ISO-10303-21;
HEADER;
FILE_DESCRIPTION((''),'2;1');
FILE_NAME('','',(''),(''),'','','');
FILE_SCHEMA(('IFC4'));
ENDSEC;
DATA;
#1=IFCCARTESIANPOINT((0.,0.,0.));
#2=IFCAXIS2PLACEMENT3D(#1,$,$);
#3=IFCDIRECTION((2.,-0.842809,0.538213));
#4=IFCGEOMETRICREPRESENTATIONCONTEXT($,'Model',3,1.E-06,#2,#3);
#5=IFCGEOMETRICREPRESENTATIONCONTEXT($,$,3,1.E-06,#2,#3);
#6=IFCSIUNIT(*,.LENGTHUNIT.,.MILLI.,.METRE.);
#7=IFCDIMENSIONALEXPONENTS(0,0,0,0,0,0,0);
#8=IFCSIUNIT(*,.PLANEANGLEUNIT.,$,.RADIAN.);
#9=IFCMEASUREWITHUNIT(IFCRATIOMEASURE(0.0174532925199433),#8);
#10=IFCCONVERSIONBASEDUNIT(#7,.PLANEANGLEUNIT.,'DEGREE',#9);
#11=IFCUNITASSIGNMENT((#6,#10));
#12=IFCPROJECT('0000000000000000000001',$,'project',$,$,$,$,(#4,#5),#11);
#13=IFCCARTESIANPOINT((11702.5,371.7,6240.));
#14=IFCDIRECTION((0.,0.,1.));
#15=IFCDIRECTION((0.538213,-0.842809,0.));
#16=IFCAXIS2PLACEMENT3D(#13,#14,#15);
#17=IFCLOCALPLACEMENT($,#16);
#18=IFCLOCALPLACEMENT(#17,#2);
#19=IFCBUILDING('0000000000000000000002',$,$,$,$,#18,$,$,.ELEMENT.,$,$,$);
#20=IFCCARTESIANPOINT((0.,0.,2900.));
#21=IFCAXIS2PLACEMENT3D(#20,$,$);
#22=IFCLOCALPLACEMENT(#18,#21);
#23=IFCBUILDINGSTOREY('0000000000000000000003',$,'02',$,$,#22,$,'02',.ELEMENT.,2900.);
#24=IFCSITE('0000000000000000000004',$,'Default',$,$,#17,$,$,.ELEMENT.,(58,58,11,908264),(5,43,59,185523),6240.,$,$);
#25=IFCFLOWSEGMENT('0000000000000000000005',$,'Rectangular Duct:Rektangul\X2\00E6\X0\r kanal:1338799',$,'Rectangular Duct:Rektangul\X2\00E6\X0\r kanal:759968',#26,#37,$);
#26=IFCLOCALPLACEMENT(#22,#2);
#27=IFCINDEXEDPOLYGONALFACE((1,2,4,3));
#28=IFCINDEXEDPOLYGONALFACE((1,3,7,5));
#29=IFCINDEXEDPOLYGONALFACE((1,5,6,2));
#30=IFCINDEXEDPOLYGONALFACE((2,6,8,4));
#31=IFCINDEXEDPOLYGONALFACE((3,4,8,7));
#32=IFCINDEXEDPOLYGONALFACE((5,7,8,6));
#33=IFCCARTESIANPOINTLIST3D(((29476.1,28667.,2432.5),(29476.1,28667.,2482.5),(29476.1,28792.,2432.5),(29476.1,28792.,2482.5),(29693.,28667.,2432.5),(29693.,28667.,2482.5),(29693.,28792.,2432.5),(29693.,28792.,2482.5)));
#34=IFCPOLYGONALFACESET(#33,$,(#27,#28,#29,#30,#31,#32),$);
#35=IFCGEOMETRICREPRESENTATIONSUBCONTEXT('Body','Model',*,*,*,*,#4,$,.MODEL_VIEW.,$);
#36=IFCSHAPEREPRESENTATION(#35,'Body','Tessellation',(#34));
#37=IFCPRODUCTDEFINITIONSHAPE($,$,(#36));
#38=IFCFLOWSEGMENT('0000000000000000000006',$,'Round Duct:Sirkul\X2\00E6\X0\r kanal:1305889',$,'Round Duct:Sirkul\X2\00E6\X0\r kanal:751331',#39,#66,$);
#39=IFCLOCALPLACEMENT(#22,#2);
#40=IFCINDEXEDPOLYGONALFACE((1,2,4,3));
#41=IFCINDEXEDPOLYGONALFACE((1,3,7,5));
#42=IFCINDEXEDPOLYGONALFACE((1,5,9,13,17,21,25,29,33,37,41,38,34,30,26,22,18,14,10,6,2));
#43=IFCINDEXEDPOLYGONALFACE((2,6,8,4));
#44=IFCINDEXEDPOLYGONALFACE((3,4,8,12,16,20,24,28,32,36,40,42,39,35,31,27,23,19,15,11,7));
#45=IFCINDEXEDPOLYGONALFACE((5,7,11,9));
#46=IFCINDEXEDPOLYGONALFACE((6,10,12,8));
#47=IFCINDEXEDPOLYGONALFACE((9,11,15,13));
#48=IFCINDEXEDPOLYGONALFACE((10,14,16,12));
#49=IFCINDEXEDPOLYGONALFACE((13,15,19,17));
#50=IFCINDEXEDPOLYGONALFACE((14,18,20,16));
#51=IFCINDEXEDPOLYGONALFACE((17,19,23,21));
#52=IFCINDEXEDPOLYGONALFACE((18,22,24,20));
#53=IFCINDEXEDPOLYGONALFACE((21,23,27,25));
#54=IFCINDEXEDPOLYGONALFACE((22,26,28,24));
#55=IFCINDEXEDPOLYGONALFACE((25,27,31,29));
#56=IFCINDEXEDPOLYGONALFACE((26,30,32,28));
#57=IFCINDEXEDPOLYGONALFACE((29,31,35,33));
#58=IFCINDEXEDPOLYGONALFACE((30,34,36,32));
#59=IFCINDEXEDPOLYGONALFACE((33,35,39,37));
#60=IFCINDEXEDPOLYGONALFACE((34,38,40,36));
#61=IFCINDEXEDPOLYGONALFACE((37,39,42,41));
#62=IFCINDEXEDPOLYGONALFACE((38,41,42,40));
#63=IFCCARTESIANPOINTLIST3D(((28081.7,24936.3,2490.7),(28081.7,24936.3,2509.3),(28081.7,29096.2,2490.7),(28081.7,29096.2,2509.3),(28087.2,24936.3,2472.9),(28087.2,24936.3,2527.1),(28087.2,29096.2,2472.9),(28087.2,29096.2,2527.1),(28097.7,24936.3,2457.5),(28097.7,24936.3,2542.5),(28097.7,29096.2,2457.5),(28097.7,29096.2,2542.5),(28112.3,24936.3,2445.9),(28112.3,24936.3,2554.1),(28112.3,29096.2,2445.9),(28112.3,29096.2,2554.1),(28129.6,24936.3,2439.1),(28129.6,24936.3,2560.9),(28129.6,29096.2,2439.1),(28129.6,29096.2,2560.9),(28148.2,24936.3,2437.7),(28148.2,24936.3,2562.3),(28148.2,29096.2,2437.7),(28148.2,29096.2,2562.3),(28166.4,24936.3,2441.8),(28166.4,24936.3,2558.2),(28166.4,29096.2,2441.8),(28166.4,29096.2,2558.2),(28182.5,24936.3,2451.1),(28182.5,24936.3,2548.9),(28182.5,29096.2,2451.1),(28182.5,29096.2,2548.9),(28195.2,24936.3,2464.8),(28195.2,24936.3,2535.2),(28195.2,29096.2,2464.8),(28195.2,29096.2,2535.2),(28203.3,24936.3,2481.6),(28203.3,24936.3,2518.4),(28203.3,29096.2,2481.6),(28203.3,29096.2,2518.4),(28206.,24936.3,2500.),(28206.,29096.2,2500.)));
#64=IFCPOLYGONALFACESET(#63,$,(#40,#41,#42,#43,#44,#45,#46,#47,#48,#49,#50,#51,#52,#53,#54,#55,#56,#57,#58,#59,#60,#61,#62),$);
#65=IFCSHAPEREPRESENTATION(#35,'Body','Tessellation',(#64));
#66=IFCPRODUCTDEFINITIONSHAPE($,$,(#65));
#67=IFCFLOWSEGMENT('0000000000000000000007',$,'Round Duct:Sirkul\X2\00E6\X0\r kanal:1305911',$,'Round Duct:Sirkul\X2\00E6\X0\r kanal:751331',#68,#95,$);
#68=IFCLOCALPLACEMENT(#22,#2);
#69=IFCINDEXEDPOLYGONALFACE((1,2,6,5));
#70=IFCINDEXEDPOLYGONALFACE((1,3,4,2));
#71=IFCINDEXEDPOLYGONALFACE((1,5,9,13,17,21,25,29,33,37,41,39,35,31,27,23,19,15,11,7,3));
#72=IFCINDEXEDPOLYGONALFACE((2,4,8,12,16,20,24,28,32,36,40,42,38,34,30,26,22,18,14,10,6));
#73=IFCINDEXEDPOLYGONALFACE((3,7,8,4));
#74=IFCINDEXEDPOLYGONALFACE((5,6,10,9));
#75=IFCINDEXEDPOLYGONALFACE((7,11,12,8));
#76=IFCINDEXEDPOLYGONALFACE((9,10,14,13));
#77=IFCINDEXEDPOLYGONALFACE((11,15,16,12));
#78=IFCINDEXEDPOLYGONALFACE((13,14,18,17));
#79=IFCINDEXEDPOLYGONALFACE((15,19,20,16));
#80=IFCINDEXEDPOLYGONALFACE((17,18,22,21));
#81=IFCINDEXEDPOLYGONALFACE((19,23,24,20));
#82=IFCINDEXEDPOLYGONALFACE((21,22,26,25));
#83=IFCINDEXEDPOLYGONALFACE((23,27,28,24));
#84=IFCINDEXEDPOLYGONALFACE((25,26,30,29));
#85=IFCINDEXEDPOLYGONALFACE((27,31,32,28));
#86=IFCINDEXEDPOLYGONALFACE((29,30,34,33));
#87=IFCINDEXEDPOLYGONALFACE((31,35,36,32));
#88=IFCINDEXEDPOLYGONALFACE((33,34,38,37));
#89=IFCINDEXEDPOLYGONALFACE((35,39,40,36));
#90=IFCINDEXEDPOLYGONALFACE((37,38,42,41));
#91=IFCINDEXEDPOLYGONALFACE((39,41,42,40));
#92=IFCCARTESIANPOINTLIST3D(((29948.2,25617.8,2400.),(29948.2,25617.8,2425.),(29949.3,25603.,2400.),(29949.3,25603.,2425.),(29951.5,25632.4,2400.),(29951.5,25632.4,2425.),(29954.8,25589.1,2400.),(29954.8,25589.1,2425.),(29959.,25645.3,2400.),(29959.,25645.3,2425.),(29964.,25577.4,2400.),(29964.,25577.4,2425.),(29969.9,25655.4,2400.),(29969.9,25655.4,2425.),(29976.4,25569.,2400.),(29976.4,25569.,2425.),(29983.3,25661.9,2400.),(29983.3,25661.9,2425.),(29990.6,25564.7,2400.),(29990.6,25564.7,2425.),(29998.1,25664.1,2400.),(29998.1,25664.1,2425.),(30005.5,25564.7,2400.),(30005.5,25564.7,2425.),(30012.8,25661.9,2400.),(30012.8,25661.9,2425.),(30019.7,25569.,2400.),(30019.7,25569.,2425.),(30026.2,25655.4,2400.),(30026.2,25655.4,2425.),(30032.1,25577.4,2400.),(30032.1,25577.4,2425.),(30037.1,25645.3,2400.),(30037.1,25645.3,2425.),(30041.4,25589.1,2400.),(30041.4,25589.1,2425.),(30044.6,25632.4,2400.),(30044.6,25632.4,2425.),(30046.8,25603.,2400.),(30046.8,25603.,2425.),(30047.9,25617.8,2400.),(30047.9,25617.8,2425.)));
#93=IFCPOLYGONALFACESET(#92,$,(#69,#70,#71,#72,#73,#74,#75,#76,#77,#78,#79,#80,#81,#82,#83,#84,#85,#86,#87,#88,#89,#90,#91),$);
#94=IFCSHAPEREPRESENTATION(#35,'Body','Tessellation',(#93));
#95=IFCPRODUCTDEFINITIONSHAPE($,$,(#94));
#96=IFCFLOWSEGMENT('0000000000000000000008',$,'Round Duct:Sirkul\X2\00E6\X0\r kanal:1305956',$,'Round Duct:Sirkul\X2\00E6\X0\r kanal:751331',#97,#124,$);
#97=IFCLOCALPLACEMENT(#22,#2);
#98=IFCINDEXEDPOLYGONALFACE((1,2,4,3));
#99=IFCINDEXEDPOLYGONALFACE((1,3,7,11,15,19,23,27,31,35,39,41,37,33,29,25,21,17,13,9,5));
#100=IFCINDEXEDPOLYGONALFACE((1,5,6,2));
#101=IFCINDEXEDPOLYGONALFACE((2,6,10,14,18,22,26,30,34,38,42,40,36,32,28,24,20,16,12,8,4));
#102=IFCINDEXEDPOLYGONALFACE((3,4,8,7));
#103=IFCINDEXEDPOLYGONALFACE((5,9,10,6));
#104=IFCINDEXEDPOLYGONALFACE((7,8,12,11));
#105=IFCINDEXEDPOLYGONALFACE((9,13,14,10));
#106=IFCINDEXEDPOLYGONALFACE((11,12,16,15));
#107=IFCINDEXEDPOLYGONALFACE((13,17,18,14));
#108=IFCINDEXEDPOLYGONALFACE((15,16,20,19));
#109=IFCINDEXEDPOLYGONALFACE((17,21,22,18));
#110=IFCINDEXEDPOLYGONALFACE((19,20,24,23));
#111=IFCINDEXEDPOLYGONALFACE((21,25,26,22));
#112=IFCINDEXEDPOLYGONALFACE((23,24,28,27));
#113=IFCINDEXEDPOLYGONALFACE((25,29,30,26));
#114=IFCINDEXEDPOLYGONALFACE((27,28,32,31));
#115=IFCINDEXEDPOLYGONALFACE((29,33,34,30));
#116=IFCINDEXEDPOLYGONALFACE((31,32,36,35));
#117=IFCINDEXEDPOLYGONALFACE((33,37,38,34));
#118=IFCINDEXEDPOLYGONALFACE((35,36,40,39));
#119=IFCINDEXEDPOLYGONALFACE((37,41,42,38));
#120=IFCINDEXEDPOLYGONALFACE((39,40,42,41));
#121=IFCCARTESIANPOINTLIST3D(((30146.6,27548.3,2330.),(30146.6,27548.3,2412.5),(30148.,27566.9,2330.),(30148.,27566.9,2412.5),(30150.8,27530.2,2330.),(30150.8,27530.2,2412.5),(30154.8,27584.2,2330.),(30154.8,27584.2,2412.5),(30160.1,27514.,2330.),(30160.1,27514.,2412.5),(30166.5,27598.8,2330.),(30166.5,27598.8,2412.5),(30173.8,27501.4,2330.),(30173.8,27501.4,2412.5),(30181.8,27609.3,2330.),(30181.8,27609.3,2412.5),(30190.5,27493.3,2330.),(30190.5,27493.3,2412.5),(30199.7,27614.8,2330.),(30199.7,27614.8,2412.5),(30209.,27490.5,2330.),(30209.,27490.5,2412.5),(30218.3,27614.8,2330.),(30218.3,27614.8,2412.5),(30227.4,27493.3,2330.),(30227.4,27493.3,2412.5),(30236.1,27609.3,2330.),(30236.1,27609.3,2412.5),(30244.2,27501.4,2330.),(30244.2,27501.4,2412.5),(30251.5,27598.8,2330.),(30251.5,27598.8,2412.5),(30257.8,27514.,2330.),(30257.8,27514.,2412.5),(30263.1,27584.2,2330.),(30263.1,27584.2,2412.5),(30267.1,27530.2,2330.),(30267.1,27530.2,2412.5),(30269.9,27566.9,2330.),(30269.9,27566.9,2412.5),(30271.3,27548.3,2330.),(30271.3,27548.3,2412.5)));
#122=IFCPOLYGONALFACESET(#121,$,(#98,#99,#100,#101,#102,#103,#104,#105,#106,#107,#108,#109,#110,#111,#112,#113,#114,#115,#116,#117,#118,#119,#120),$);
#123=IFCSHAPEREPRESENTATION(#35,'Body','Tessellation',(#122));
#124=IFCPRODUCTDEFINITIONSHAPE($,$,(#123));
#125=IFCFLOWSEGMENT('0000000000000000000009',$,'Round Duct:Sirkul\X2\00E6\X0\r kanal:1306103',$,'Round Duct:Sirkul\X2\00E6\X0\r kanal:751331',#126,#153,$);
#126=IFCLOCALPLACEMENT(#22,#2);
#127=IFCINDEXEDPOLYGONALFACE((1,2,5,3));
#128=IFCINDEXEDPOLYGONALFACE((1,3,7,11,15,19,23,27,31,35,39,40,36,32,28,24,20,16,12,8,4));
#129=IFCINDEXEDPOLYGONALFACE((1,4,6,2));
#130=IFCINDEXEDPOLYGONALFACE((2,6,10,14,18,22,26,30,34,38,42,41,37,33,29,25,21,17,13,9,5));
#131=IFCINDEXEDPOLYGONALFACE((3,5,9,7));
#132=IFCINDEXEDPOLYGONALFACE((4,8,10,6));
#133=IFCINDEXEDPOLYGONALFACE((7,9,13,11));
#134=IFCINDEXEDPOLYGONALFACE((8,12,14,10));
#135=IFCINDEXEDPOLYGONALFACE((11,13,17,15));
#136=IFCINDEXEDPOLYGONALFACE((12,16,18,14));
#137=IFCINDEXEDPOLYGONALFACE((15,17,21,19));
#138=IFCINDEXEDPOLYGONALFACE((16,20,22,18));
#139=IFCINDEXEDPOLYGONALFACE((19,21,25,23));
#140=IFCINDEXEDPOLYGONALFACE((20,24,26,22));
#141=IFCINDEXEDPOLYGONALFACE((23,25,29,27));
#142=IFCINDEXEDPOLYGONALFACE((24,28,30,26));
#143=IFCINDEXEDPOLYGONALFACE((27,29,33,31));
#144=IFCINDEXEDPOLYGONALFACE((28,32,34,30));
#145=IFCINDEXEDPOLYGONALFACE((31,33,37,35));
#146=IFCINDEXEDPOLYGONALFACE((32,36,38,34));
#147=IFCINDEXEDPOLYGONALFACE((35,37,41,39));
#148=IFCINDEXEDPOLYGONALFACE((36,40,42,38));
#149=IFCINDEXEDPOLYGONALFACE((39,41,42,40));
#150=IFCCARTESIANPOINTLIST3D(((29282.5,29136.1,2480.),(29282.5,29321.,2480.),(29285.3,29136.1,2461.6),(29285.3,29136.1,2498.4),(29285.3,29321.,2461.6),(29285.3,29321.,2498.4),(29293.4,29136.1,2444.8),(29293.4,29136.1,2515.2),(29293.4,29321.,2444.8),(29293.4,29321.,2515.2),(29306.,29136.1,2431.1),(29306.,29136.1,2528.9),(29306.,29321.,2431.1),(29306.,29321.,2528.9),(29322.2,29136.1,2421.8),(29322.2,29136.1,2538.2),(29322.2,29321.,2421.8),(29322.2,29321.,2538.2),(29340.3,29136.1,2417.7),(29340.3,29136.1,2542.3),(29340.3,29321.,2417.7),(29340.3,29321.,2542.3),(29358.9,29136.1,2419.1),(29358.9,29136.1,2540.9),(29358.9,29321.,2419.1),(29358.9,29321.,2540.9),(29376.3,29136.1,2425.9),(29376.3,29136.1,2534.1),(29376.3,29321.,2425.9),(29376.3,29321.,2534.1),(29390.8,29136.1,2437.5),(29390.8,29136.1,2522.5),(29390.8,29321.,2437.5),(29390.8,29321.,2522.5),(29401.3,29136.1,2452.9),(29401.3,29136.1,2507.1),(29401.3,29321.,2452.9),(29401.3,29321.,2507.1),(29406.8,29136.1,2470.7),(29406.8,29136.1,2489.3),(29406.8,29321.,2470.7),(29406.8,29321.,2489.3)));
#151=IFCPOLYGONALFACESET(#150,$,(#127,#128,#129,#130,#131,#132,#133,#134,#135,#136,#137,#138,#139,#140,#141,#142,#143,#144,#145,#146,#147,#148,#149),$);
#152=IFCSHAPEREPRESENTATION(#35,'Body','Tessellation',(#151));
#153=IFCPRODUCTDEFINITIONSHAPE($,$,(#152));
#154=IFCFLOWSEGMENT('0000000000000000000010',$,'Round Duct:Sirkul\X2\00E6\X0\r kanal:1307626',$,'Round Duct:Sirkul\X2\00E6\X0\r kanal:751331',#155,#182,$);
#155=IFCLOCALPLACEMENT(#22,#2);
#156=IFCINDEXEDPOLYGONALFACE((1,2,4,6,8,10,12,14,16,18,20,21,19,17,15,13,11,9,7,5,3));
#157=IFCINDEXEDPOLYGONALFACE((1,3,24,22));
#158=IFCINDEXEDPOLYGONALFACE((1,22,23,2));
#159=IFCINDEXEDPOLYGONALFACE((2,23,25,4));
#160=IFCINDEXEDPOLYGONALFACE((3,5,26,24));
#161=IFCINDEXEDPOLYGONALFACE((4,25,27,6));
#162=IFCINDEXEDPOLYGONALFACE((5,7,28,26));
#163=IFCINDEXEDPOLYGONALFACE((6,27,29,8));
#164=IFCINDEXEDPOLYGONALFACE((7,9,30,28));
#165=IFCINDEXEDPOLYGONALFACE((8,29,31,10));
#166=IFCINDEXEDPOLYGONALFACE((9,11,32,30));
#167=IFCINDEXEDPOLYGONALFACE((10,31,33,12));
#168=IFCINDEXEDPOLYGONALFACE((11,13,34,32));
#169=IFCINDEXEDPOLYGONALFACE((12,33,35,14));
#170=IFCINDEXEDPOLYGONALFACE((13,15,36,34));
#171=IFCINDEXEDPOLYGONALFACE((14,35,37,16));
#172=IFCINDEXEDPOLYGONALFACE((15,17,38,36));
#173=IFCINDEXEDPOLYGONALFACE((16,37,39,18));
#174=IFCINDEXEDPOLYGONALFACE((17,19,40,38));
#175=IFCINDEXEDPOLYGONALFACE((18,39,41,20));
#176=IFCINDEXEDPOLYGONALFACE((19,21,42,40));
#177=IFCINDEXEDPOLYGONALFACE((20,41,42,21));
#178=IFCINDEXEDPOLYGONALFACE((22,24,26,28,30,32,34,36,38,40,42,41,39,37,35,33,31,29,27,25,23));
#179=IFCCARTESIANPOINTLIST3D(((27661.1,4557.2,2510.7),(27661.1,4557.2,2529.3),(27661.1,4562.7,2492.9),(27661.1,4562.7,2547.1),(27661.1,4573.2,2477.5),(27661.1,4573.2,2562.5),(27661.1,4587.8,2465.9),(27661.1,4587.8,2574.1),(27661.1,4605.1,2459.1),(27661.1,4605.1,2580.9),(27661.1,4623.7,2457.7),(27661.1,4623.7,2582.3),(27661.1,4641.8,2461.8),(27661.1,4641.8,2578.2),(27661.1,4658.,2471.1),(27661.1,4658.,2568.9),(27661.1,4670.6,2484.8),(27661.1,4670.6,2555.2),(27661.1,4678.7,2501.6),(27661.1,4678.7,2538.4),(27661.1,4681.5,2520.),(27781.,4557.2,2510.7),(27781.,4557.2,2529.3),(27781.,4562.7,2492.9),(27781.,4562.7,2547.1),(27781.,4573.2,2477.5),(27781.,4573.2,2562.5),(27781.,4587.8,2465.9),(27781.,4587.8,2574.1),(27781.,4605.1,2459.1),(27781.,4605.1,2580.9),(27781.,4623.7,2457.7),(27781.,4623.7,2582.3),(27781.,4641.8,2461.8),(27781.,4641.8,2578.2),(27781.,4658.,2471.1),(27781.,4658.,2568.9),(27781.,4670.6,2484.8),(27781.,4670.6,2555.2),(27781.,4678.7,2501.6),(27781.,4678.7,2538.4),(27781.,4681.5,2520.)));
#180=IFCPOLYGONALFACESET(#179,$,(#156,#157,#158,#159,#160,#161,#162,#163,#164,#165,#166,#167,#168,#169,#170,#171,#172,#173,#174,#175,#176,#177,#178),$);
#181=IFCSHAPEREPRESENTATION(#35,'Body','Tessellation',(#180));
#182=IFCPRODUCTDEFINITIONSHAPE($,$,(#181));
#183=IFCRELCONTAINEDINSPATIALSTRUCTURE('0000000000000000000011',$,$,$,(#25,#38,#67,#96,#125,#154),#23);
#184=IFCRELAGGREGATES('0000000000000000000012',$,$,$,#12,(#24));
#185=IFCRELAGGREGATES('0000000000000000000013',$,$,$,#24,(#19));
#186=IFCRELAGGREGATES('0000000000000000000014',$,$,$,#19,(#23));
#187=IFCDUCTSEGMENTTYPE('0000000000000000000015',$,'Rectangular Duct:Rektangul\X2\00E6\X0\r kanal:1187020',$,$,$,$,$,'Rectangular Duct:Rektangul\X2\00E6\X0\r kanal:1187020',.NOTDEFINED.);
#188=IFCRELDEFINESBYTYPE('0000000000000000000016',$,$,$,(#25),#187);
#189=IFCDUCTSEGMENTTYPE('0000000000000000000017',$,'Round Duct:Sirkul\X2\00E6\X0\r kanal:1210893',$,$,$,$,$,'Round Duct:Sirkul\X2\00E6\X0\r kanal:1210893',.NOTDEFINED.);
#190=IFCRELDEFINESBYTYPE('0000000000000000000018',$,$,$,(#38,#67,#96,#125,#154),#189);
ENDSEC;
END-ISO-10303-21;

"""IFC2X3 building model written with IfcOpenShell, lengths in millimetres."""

from ifc_helpers import new_model, entity, si_unit, converted_unit, direction, frame, frame_2d, origin, origin_2d_with_axis, place, context, subcontext, project, spatial, rectangle, circle, extrude, type_object, element, save


model = new_model("IFC2X3")

# Units and contexts
model_context = context("Model", 3, precision=1e-06, world=origin(), true_north=direction((2.0, -0.842809, 0.538213)))
context_of_model = context(None, 3, precision=1e-06, world=origin(), true_north=direction((2.0, -0.842809, 0.538213)))
body_context = subcontext(model_context, "Body", "Model", "MODEL_VIEW")
ifc_project = project(units=[si_unit("LENGTHUNIT", "METRE", prefix="MILLI"), converted_unit("PLANEANGLEUNIT", "DEGREE", entity("IfcRatioMeasure", 0.0174532925199433), si_unit("PLANEANGLEUNIT", "RADIAN"), dimensions=[0, 0, 0, 0, 0, 0, 0])], contexts=[model_context, context_of_model])

# Site, building, storey
site_placement = place(None, frame((11702.5, 371.7, 6240.0), z_axis=(0.0, 0.0, 1.0), x_axis=(0.538213, -0.842809, 0.0)))
site = spatial("IfcSite", under=ifc_project, at=site_placement, Name="Default", CompositionType="ELEMENT", RefLatitude=(58, 58, 11, 908264), RefLongitude=(5, 43, 59, 185523), RefElevation=6240.0)
building_placement = place(site_placement, origin())
building = spatial("IfcBuilding", under=site, at=building_placement, CompositionType="ELEMENT")
storey_placement = place(building_placement, frame((0.0, 0.0, 2900.0)))
storey = spatial("IfcBuildingStorey", under=building, at=storey_placement, Name="02", LongName="02", CompositionType="ELEMENT", Elevation=2900.0)

# Flow segments
duct_segment_type_1 = type_object("IfcDuctSegmentType", Name="Rectangular Duct:Rektangulær kanal:1187020", ElementType="Rectangular Duct:Rektangulær kanal:1187020", PredefinedType="NOTDEFINED")
flow_segment_1_placement = place(storey_placement, origin())
element("IfcFlowSegment", 1, at=flow_segment_1_placement, inside=storey, type_object=duct_segment_type_1, Name="Rectangular Duct:Rektangulær kanal:1338799", ObjectType="Rectangular Duct:Rektangulær kanal:759968", context=body_context, shape_type="SweptSolid", body=[
    extrude(rectangle(XDim=216.9, YDim=125.0, at=frame_2d((0.0, 0.0), x_axis=(1.0, 0.0))), frame((29584.6, 28729.5, 2432.5), z_axis=(0.0, 0.0, 1.0), x_axis=(-1.0, 0.0, 0.0)), (0.0, 0.0, 1.0), 50.0),
])
duct_segment_type_2 = type_object("IfcDuctSegmentType", Name="Round Duct:Sirkulær kanal:1210893", ElementType="Round Duct:Sirkulær kanal:1210893", PredefinedType="NOTDEFINED")
flow_segment_2_placement = place(storey_placement, origin())
element("IfcFlowSegment", 2, at=flow_segment_2_placement, inside=storey, type_object=duct_segment_type_2, Name="Round Duct:Sirkulær kanal:1305889", ObjectType="Round Duct:Sirkulær kanal:751331", context=body_context, shape_type="SweptSolid", body=[
    extrude(circle(Radius=62.5, at=origin_2d_with_axis()), frame((28143.5, 24936.3, 2500.0), z_axis=(0.0, 1.0, 0.0), x_axis=(1.0, 0.0, 0.0)), (0.0, 0.0, 1.0), 4159.9),
])
flow_segment_3_placement = place(storey_placement, origin())
element("IfcFlowSegment", 3, at=flow_segment_3_placement, inside=storey, type_object=duct_segment_type_2, Name="Round Duct:Sirkulær kanal:1305911", ObjectType="Round Duct:Sirkulær kanal:751331", context=body_context, shape_type="SweptSolid", body=[
    extrude(circle(Radius=50.0, at=frame_2d((0.0, 0.0), x_axis=(1.0, 0.0))), frame((29998.1, 25614.1, 2400.0), z_axis=(0.0, 0.0, 1.0), x_axis=(0.0, 1.0, 0.0)), (0.0, 0.0, 1.0), 25.0),
])
flow_segment_4_placement = place(storey_placement, origin())
element("IfcFlowSegment", 4, at=flow_segment_4_placement, inside=storey, type_object=duct_segment_type_2, Name="Round Duct:Sirkulær kanal:1305956", ObjectType="Round Duct:Sirkulær kanal:751331", context=body_context, shape_type="SweptSolid", body=[
    extrude(circle(Radius=62.5, at=frame_2d((0.0, 0.0), x_axis=(1.0, 0.0))), frame((30209.0, 27553.0, 2330.0), z_axis=(0.0, 0.0, 1.0), x_axis=(0.0, -1.0, 0.0)), (0.0, 0.0, 1.0), 82.5),
])
flow_segment_5_placement = place(storey_placement, origin())
element("IfcFlowSegment", 5, at=flow_segment_5_placement, inside=storey, type_object=duct_segment_type_2, Name="Round Duct:Sirkulær kanal:1306103", ObjectType="Round Duct:Sirkulær kanal:751331", context=body_context, shape_type="SweptSolid", body=[
    extrude(circle(Radius=62.5, at=origin_2d_with_axis()), frame((29345.0, 29136.1, 2480.0), z_axis=(0.0, 1.0, 0.0), x_axis=(-1.0, 0.0, 0.0)), (0.0, 0.0, 1.0), 184.9),
])
flow_segment_6_placement = place(storey_placement, origin())
element("IfcFlowSegment", 6, at=flow_segment_6_placement, inside=storey, type_object=duct_segment_type_2, Name="Round Duct:Sirkulær kanal:1307626", ObjectType="Round Duct:Sirkulær kanal:751331", context=body_context, shape_type="SweptSolid", body=[
    extrude(circle(Radius=62.5, at=frame_2d((0.0, 0.0), x_axis=(1.0, 0.0))), frame((27661.1, 4619.0, 2520.0), z_axis=(1.0, 0.0, 0.0), x_axis=(0.0, 1.0, 0.0)), (0.0, 0.0, 1.0), 119.9),
])

save(model, "model.ifc")
